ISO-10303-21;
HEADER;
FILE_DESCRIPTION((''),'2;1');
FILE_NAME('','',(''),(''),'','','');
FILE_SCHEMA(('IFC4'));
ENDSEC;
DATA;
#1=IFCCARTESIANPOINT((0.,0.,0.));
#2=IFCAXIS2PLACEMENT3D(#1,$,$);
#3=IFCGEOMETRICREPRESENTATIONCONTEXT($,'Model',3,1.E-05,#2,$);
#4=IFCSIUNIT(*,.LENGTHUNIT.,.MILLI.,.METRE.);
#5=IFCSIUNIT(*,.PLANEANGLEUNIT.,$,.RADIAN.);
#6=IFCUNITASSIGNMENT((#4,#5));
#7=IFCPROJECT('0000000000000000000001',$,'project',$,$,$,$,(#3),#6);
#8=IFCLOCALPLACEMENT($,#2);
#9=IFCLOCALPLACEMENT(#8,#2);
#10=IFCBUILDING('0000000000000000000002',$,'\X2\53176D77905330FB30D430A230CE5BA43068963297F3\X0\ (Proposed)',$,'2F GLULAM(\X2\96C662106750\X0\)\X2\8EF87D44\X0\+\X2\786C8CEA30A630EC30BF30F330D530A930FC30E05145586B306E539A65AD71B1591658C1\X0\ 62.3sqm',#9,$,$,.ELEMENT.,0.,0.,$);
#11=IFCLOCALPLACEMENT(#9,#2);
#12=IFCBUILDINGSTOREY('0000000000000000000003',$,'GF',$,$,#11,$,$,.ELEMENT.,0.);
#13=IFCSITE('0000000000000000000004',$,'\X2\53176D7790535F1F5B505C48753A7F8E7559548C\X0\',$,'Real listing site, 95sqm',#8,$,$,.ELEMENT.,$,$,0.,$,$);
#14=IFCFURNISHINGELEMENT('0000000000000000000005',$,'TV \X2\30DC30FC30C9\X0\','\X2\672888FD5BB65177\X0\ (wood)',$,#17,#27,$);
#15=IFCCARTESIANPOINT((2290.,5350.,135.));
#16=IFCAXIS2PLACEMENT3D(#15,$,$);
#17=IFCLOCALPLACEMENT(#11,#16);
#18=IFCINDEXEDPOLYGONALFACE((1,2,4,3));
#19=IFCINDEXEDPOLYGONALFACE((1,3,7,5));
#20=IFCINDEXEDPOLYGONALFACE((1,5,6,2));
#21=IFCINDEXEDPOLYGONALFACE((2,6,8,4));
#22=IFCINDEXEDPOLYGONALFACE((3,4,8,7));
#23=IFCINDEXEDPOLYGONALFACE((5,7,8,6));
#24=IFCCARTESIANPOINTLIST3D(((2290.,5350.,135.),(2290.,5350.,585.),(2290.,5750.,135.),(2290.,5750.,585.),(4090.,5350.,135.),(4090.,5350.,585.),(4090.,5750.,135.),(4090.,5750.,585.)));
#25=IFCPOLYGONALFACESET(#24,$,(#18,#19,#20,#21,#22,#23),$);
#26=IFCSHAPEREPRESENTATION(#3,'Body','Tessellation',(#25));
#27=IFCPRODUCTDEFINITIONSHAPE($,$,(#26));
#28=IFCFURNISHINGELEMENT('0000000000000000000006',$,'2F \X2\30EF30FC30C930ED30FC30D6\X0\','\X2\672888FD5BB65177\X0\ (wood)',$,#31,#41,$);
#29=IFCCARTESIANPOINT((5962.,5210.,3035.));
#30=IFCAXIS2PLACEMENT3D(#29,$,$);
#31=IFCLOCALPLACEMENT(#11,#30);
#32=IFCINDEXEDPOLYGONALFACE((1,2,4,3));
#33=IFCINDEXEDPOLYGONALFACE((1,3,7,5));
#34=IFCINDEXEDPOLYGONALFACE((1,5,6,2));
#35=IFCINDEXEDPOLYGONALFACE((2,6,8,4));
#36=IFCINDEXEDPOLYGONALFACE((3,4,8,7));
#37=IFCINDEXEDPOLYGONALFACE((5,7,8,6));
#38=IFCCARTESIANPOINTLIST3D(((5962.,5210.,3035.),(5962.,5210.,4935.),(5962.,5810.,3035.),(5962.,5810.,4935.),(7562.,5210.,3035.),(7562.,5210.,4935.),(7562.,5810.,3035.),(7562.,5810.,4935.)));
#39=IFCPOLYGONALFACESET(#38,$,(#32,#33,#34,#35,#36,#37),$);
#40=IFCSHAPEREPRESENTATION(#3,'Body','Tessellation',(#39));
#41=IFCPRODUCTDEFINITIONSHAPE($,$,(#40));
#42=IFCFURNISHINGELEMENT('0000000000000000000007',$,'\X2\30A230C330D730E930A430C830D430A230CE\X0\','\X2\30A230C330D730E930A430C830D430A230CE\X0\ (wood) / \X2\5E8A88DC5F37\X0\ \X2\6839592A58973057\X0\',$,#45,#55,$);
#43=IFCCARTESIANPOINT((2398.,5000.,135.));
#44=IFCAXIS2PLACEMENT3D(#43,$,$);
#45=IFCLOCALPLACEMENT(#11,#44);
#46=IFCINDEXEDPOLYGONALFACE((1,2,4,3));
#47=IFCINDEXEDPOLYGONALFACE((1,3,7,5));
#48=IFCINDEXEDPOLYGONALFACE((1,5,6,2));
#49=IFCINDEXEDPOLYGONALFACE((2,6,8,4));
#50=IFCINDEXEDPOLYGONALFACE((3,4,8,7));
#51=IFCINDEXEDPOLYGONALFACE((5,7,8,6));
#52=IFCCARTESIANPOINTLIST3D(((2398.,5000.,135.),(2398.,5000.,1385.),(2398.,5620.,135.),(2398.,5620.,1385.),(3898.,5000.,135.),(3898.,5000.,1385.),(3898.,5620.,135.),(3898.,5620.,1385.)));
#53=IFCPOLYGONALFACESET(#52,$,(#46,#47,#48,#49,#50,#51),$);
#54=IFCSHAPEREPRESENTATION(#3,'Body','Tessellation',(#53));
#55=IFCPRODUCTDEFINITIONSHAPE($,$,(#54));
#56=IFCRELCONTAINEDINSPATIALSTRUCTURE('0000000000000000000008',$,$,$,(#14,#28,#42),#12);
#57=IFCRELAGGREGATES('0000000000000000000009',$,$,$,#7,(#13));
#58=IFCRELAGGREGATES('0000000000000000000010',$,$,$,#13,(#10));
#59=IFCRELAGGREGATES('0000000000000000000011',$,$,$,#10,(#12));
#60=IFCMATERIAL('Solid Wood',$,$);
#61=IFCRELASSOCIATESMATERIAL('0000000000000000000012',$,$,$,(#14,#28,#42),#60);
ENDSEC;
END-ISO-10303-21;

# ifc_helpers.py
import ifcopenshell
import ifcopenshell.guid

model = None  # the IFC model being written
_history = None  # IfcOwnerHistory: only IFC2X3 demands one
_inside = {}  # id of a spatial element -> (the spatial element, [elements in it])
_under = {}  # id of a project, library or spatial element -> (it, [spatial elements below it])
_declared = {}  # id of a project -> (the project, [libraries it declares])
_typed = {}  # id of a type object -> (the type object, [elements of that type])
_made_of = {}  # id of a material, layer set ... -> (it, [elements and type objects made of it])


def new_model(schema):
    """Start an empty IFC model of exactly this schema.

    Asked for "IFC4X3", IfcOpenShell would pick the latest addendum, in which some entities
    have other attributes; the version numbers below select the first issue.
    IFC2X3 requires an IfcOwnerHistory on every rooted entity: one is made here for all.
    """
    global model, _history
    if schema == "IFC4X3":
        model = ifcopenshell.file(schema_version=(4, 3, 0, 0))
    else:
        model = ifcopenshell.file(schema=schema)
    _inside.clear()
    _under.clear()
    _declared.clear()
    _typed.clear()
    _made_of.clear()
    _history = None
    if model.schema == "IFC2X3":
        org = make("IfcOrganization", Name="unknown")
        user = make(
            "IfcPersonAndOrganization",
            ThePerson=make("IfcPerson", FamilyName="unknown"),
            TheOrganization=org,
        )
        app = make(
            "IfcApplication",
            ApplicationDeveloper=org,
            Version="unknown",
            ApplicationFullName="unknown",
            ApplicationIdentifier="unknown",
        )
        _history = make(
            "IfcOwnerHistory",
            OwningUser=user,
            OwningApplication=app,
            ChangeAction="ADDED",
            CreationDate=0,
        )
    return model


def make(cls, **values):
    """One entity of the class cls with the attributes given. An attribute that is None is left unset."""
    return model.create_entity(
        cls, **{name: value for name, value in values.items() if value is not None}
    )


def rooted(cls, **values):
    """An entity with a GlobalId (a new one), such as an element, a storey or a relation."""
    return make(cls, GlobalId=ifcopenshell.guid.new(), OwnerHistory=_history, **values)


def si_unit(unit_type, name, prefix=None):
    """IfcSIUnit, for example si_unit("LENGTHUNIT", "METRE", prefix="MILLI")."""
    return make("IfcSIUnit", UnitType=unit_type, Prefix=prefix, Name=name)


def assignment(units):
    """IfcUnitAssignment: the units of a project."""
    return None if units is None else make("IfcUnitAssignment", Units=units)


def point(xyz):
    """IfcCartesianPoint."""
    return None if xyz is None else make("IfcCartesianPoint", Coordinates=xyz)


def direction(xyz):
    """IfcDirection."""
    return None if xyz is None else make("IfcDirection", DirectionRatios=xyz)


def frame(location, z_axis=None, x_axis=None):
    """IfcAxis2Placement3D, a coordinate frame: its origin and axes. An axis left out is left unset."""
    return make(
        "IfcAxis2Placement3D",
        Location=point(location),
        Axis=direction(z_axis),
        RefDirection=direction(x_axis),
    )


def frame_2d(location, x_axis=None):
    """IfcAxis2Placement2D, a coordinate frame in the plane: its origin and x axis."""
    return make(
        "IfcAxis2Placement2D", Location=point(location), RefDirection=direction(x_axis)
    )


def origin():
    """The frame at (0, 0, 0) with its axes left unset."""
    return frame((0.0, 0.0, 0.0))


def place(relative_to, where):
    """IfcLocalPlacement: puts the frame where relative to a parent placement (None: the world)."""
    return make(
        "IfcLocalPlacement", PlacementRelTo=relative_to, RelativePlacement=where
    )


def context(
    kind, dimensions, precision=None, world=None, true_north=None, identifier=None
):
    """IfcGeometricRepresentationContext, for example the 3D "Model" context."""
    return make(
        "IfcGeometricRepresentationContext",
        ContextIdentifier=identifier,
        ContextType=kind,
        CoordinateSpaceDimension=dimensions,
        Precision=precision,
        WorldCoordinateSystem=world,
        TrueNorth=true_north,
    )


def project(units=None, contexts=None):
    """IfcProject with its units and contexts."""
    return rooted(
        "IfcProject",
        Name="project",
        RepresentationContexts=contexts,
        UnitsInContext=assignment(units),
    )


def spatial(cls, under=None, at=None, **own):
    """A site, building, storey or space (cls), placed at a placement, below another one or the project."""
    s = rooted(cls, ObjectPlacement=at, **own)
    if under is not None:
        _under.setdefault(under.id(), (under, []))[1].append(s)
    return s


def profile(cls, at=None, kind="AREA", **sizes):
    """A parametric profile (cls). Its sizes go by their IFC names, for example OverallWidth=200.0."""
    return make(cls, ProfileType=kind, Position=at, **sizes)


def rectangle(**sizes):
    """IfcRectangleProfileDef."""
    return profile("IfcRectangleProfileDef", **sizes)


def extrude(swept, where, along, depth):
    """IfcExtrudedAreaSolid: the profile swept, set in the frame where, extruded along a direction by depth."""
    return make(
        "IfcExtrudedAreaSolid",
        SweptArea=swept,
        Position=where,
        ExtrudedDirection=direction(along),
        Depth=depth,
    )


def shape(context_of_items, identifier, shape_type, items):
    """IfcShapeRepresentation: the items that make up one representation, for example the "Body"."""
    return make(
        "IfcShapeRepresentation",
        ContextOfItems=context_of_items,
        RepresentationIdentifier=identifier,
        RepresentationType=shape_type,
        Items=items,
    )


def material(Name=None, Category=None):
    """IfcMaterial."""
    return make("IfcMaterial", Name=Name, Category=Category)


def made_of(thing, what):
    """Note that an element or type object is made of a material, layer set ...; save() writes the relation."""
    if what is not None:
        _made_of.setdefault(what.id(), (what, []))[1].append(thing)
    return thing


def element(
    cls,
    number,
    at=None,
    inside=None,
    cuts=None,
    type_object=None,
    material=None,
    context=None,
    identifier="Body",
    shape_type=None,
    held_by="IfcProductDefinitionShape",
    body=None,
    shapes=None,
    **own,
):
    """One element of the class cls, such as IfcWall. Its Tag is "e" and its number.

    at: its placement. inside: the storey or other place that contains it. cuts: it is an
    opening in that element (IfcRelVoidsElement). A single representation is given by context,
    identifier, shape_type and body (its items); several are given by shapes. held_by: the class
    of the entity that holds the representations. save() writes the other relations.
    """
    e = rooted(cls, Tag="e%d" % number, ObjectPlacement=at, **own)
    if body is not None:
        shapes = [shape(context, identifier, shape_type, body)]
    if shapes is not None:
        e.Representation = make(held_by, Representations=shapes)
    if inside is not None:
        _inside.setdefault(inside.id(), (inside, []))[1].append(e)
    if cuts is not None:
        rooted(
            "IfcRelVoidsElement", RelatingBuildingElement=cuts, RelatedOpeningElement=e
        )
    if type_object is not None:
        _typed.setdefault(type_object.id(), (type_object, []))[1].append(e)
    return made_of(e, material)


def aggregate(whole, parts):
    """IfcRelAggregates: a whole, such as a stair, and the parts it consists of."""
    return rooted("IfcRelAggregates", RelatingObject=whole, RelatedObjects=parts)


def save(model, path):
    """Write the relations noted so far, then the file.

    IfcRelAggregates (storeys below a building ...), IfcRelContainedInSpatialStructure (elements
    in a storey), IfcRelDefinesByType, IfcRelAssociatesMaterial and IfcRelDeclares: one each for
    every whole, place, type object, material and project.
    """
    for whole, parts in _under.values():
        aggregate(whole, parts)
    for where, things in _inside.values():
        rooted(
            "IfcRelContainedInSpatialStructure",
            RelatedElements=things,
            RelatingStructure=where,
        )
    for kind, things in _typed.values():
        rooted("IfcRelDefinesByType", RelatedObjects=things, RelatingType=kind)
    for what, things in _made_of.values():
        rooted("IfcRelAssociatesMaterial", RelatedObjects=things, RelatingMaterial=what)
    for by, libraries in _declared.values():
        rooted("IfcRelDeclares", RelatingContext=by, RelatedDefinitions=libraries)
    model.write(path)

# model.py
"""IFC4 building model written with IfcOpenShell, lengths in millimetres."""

from ifc_helpers import new_model, si_unit, frame, frame_2d, origin, place, context, project, spatial, rectangle, extrude, material, element, save


model = new_model("IFC4")

# Units and contexts
model_context = context("Model", 3, precision=1e-05, world=origin())
ifc_project = project(units=[si_unit("LENGTHUNIT", "METRE", prefix="MILLI"), si_unit("PLANEANGLEUNIT", "RADIAN")], contexts=[model_context])

# Site, building, storey
site_placement = place(None, origin())
site = spatial("IfcSite", under=ifc_project, at=site_placement, Name="北海道弟子屈町美留和", ObjectType="Real listing site, 95sqm", CompositionType="ELEMENT", RefElevation=0.0)
building_placement = place(site_placement, origin())
building = spatial("IfcBuilding", under=site, at=building_placement, Name="北海道・ピアノ室と防音 (Proposed)", ObjectType="2F GLULAM(集成材)軸組+硬質ウレタンフォーム充填の厚断熱外壁 62.3sqm", CompositionType="ELEMENT", ElevationOfRefHeight=0.0, ElevationOfTerrain=0.0)
storey_placement = place(building_placement, origin())
storey = spatial("IfcBuildingStorey", under=building, at=storey_placement, Name="GF", CompositionType="ELEMENT", Elevation=0.0)

# Shared definitions
ifc_material_1 = material(Name="Solid Wood")

# Furnishing elements
furnishing_1_placement = place(storey_placement, frame((2290.0, 5350.0, 135.0)))
element("IfcFurnishingElement", 1, at=furnishing_1_placement, inside=storey, material=ifc_material_1, Name="TV ボード", Description="木製家具 (wood)", context=model_context, shape_type="SweptSolid", body=[
    extrude(rectangle(XDim=1800.0, YDim=400.0, at=frame_2d((900.0, 200.0))), frame((2290.0, 5350.0, 135.0)), (0.0, 0.0, 1.0), 450.0),
])
furnishing_2_placement = place(storey_placement, frame((5962.0, 5210.0, 3035.0)))
element("IfcFurnishingElement", 2, at=furnishing_2_placement, inside=storey, material=ifc_material_1, Name="2F ワードローブ", Description="木製家具 (wood)", context=model_context, shape_type="SweptSolid", body=[
    extrude(rectangle(XDim=1600.0, YDim=600.0, at=frame_2d((800.0, 300.0))), frame((5962.0, 5210.0, 3035.0)), (0.0, 0.0, 1.0), 1900.0),
])
furnishing_3_placement = place(storey_placement, frame((2398.0, 5000.0, 135.0)))
element("IfcFurnishingElement", 3, at=furnishing_3_placement, inside=storey, material=ifc_material_1, Name="アップライトピアノ", Description="アップライトピアノ (wood) / 床補強 根太増し", context=model_context, shape_type="SweptSolid", body=[
    extrude(rectangle(XDim=1500.0, YDim=620.0, at=frame_2d((750.0, 310.0))), frame((2398.0, 5000.0, 135.0)), (0.0, 0.0, 1.0), 1250.0),
])

save(model, "model.ifc")
